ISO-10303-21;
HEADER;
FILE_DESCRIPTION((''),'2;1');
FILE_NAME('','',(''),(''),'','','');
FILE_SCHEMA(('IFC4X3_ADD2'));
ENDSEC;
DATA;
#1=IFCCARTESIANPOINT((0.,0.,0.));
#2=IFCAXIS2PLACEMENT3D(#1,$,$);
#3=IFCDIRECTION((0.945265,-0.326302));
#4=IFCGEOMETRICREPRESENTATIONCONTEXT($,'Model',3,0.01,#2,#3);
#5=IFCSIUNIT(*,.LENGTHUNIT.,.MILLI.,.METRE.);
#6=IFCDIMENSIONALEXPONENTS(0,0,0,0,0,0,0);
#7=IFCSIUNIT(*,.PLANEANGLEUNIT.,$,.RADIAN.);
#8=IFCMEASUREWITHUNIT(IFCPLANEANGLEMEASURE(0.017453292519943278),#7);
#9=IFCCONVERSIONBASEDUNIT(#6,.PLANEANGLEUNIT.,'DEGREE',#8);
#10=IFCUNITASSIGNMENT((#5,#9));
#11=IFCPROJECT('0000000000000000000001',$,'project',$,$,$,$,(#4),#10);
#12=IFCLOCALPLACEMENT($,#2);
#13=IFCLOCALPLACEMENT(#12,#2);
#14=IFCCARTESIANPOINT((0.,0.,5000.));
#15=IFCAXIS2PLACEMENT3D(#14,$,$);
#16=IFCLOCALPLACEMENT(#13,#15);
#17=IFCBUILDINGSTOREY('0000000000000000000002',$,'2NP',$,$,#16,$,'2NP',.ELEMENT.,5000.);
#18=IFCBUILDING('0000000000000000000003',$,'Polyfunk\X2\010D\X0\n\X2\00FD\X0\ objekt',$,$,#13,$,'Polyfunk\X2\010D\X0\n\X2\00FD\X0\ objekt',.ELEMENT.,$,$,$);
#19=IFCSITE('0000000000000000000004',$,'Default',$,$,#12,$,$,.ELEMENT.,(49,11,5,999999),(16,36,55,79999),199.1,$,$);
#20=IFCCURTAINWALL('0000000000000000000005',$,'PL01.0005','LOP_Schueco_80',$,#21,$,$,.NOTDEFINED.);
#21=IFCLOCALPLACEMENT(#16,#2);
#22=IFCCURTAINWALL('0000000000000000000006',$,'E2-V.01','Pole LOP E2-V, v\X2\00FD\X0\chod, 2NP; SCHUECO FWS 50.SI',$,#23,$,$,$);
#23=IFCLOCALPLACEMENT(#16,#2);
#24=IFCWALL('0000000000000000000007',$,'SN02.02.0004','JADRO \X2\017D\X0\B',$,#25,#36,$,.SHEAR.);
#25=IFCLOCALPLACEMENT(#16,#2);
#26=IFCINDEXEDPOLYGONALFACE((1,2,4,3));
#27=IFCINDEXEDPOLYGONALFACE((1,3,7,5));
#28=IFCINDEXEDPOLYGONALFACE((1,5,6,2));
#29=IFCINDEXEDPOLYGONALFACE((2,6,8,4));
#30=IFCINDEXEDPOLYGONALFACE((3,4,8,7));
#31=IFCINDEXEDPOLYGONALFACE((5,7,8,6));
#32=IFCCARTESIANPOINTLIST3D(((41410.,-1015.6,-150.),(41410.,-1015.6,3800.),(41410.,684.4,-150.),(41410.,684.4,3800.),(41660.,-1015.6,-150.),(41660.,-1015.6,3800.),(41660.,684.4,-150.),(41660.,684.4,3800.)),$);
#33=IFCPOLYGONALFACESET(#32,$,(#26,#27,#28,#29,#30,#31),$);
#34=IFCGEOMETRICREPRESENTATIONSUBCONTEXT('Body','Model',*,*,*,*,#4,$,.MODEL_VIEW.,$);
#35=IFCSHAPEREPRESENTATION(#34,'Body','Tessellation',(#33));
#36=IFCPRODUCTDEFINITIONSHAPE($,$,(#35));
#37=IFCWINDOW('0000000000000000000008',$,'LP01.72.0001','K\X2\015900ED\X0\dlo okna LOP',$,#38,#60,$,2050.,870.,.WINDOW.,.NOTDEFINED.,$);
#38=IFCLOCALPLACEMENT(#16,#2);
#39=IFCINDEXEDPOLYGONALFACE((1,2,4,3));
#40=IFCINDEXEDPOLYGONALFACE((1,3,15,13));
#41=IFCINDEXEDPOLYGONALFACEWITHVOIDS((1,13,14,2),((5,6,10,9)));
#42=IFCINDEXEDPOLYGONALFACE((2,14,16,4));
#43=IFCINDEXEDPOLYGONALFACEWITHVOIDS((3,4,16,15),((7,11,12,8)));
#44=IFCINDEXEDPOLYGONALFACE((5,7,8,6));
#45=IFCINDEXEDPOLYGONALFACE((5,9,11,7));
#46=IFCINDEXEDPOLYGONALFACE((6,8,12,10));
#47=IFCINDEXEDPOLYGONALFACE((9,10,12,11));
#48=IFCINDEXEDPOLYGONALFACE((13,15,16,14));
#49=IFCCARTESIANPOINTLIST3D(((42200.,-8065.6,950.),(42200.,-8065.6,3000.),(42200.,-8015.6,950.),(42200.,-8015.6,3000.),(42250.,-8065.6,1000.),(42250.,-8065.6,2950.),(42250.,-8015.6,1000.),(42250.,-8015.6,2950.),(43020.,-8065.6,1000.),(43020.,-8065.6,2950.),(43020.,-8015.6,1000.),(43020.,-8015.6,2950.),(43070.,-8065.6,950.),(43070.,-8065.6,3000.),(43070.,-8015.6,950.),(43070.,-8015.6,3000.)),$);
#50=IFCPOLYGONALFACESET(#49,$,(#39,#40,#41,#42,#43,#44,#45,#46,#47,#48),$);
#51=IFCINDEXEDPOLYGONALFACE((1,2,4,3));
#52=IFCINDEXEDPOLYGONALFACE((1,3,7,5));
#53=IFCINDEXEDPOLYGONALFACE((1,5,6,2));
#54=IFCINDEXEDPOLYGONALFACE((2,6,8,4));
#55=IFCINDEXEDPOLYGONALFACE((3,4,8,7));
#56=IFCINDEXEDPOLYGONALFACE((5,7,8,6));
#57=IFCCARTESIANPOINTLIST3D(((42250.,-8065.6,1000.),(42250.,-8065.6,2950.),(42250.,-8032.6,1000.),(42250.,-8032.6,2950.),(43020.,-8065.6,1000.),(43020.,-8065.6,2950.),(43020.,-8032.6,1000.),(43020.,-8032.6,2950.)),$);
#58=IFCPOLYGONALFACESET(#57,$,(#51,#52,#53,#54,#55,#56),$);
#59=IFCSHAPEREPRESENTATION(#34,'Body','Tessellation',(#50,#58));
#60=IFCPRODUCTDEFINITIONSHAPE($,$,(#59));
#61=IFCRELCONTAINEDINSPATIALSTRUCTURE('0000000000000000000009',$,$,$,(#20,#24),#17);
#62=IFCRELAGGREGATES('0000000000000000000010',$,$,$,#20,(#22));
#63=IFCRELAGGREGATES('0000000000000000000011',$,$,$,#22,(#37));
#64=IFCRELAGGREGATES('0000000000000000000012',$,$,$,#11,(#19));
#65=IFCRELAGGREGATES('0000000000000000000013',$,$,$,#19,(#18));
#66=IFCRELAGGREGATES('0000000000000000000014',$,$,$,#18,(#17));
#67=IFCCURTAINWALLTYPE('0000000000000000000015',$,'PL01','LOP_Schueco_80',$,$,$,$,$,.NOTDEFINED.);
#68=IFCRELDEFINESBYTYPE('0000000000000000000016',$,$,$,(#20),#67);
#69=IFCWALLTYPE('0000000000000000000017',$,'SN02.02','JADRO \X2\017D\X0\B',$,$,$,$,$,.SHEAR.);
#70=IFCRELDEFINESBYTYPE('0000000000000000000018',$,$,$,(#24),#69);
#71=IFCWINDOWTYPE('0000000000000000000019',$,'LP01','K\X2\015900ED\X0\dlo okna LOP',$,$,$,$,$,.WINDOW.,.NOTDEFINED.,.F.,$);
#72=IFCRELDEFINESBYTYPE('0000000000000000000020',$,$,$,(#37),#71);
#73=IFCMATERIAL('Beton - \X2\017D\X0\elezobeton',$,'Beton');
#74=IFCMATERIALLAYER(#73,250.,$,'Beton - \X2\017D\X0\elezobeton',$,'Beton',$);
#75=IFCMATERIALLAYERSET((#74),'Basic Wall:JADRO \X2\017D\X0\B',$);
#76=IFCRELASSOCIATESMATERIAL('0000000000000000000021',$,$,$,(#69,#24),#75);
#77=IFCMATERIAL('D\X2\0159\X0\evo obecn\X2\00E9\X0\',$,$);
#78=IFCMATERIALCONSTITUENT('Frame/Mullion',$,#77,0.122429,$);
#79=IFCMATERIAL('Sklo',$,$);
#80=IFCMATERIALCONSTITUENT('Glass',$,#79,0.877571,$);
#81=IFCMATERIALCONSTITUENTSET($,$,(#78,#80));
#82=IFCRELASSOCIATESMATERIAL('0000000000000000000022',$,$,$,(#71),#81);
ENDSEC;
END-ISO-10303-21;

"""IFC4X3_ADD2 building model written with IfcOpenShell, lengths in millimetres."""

from ifc_helpers import new_model, entity, si_unit, converted_unit, direction, frame, frame_2d, origin, place, context, subcontext, project, spatial, polyline, rectangle, outline, extrude, clip, bounded_halfspace, source, transform, mapped, material, layer, layer_set, constituent, constituent_set, type_object, type_shapes, element, aggregate, save


model = new_model("IFC4X3_ADD2")

# Units and contexts
model_context = context("Model", 3, precision=0.01, world=origin(), true_north=direction((0.945265, -0.326302)))
body_context = subcontext(model_context, "Body", "Model", "MODEL_VIEW")
ifc_project = project(units=[si_unit("LENGTHUNIT", "METRE", prefix="MILLI"), converted_unit("PLANEANGLEUNIT", "DEGREE", entity("IfcPlaneAngleMeasure", 0.017453292519943278), si_unit("PLANEANGLEUNIT", "RADIAN"), dimensions=[0, 0, 0, 0, 0, 0, 0])], contexts=[model_context])

# Site, building, storey
site_placement = place(None, origin())
site = spatial("IfcSite", under=ifc_project, at=site_placement, Name="Default", CompositionType="ELEMENT", RefLatitude=(49, 11, 5, 999999), RefLongitude=(16, 36, 55, 79999), RefElevation=199.1)
building_placement = place(site_placement, origin())
building = spatial("IfcBuilding", under=site, at=building_placement, Name="Polyfunkčný objekt", LongName="Polyfunkčný objekt", CompositionType="ELEMENT")
storey_placement = place(building_placement, frame((0.0, 0.0, 5000.0)))
storey = spatial("IfcBuildingStorey", under=building, at=storey_placement, Name="2NP", LongName="2NP", CompositionType="ELEMENT", Elevation=5000.0)

# Curtain walls
curtain_wall_type = type_object("IfcCurtainWallType", Name="PL01", Description="LOP_Schueco_80", PredefinedType="NOTDEFINED")
curtain_wall_1_placement = place(storey_placement, frame((0.0, 0.0, -5000.0)))
curtain_wall_1 = element("IfcCurtainWall", 1, at=curtain_wall_1_placement, inside=storey, type_object=curtain_wall_type, Name="PL01.0005", Description="LOP_Schueco_80", PredefinedType="NOTDEFINED")
curtain_wall_2 = element("IfcCurtainWall", 2, Name="E2-V.01", Description="Pole LOP E2-V, východ, 2NP; SCHUECO FWS 50.SI")
aggregate(curtain_wall_1, [curtain_wall_2])
ifc_material_1 = material(Name="Sklo")

# Wall
ifc_material_2 = material(Name="Beton - Železobeton", Category="Beton")
ifc_layer_1 = layer(ifc_material_2, 250.0, Name="Beton - Železobeton", Category="Beton")
ifc_layer_set_1 = layer_set([ifc_layer_1], Name="Basic Wall:JADRO ŽB")
wall_type = type_object("IfcWallType", Name="SN02.02", Description="JADRO ŽB", PredefinedType="SHEAR", material=ifc_layer_set_1)
placement = place(building_placement, origin())
wall_1_placement = place(placement, frame((41535.0, 684.4, 4850.0), z_axis=(0.0, 0.0, 1.0), x_axis=(0.0, -1.0, 0.0)))
element("IfcWall", 3, at=wall_1_placement, inside=storey, type_object=wall_type, material=ifc_layer_set_1, Name="SN02.02.0004", Description="JADRO ŽB", PredefinedType="SHEAR", context=body_context, shape_type="Clipping", body=[
    clip(clip(extrude(rectangle(XDim=1700.0, YDim=250.0, at=frame_2d((850.0, 0.0), x_axis=(-1.0, 0.0))), origin(), (0.0, 0.0, 1.0), 3950.0), bounded_halfspace(frame((1700.0, -125.0, 0.0), z_axis=(0.0, 0.0, 1.0), x_axis=(0.0, -1.0, 0.0)), True, frame((1700.0, -125.0, 0.0)), polyline([(0.0, 0.0), (0.0, 250.0), (-1700.0, 250.0), (-1700.0, 0.0), (0.0, 0.0)]))), bounded_halfspace(frame((0.0, -125.0, 3950.0), z_axis=(0.0, 0.0, -1.0), x_axis=(0.0, 1.0, 0.0)), True, frame((0.0, -125.0, 3950.0)), polyline([(0.0, 0.0), (1700.0, 0.0), (1700.0, 250.0), (0.0, 250.0), (0.0, 0.0)]))),
])

# Window
ifc_material_3 = material(Name="Dřevo obecné")
ifc_constituent_1 = constituent(ifc_material_3, Name="Frame/Mullion", fraction=0.122429)
ifc_constituent_2 = constituent(ifc_material_1, Name="Glass", fraction=0.877571)
ifc_constituent_set = constituent_set(constituents=[ifc_constituent_1, ifc_constituent_2])
window_type = type_object("IfcWindowType", Name="LP01", Description="Křídlo okna LOP", ParameterTakesPrecedence=False, PartitioningType="NOTDEFINED", PredefinedType="WINDOW", material=ifc_constituent_set)
shared_shape_1 = source(origin(), body_context, "Body", "SweptSolid", [
    extrude(outline(polyline([(-1025.0, -435.0), (1025.0, -435.0), (1025.0, 435.0), (-1025.0, 435.0), (-1025.0, -435.0)]), holes=[polyline([(-975.0, -385.0), (-975.0, 385.0), (975.0, 385.0), (975.0, -385.0), (-975.0, -385.0)])]), frame((0.0, 50.0, 1025.0), z_axis=(0.0, -1.0, 0.0), x_axis=(0.0, 0.0, -1.0)), (0.0, 0.0, 1.0), 50.0),
    extrude(rectangle(XDim=770.0, YDim=33.0, at=frame_2d((0.0, 0.0), x_axis=(1.0, 0.0))), frame((0.0, 33.5, 50.0), z_axis=(0.0, 0.0, 1.0), x_axis=(-1.0, 0.0, 0.0)), (0.0, 0.0, 1.0), 1950.0),
])
type_shapes(window_type, [shared_shape_1])
window_placement = place(curtain_wall_1_placement, frame((42635.0, -8015.6, 5950.0), z_axis=(0.0, 0.0, 1.0), x_axis=(-1.0, 0.0, 0.0)))
window = element("IfcWindow", 4, at=window_placement, type_object=window_type, Name="LP01.72.0001", Description="Křídlo okna LOP", OverallHeight=2050.0, OverallWidth=870.0, PartitioningType="NOTDEFINED", PredefinedType="WINDOW", context=body_context, shape_type="MappedRepresentation", body=[
    mapped(shared_shape_1, transform((0.0, 0.0, 0.0), scale=1.0)),
])
aggregate(curtain_wall_2, [window])

save(model, "model.ifc")
